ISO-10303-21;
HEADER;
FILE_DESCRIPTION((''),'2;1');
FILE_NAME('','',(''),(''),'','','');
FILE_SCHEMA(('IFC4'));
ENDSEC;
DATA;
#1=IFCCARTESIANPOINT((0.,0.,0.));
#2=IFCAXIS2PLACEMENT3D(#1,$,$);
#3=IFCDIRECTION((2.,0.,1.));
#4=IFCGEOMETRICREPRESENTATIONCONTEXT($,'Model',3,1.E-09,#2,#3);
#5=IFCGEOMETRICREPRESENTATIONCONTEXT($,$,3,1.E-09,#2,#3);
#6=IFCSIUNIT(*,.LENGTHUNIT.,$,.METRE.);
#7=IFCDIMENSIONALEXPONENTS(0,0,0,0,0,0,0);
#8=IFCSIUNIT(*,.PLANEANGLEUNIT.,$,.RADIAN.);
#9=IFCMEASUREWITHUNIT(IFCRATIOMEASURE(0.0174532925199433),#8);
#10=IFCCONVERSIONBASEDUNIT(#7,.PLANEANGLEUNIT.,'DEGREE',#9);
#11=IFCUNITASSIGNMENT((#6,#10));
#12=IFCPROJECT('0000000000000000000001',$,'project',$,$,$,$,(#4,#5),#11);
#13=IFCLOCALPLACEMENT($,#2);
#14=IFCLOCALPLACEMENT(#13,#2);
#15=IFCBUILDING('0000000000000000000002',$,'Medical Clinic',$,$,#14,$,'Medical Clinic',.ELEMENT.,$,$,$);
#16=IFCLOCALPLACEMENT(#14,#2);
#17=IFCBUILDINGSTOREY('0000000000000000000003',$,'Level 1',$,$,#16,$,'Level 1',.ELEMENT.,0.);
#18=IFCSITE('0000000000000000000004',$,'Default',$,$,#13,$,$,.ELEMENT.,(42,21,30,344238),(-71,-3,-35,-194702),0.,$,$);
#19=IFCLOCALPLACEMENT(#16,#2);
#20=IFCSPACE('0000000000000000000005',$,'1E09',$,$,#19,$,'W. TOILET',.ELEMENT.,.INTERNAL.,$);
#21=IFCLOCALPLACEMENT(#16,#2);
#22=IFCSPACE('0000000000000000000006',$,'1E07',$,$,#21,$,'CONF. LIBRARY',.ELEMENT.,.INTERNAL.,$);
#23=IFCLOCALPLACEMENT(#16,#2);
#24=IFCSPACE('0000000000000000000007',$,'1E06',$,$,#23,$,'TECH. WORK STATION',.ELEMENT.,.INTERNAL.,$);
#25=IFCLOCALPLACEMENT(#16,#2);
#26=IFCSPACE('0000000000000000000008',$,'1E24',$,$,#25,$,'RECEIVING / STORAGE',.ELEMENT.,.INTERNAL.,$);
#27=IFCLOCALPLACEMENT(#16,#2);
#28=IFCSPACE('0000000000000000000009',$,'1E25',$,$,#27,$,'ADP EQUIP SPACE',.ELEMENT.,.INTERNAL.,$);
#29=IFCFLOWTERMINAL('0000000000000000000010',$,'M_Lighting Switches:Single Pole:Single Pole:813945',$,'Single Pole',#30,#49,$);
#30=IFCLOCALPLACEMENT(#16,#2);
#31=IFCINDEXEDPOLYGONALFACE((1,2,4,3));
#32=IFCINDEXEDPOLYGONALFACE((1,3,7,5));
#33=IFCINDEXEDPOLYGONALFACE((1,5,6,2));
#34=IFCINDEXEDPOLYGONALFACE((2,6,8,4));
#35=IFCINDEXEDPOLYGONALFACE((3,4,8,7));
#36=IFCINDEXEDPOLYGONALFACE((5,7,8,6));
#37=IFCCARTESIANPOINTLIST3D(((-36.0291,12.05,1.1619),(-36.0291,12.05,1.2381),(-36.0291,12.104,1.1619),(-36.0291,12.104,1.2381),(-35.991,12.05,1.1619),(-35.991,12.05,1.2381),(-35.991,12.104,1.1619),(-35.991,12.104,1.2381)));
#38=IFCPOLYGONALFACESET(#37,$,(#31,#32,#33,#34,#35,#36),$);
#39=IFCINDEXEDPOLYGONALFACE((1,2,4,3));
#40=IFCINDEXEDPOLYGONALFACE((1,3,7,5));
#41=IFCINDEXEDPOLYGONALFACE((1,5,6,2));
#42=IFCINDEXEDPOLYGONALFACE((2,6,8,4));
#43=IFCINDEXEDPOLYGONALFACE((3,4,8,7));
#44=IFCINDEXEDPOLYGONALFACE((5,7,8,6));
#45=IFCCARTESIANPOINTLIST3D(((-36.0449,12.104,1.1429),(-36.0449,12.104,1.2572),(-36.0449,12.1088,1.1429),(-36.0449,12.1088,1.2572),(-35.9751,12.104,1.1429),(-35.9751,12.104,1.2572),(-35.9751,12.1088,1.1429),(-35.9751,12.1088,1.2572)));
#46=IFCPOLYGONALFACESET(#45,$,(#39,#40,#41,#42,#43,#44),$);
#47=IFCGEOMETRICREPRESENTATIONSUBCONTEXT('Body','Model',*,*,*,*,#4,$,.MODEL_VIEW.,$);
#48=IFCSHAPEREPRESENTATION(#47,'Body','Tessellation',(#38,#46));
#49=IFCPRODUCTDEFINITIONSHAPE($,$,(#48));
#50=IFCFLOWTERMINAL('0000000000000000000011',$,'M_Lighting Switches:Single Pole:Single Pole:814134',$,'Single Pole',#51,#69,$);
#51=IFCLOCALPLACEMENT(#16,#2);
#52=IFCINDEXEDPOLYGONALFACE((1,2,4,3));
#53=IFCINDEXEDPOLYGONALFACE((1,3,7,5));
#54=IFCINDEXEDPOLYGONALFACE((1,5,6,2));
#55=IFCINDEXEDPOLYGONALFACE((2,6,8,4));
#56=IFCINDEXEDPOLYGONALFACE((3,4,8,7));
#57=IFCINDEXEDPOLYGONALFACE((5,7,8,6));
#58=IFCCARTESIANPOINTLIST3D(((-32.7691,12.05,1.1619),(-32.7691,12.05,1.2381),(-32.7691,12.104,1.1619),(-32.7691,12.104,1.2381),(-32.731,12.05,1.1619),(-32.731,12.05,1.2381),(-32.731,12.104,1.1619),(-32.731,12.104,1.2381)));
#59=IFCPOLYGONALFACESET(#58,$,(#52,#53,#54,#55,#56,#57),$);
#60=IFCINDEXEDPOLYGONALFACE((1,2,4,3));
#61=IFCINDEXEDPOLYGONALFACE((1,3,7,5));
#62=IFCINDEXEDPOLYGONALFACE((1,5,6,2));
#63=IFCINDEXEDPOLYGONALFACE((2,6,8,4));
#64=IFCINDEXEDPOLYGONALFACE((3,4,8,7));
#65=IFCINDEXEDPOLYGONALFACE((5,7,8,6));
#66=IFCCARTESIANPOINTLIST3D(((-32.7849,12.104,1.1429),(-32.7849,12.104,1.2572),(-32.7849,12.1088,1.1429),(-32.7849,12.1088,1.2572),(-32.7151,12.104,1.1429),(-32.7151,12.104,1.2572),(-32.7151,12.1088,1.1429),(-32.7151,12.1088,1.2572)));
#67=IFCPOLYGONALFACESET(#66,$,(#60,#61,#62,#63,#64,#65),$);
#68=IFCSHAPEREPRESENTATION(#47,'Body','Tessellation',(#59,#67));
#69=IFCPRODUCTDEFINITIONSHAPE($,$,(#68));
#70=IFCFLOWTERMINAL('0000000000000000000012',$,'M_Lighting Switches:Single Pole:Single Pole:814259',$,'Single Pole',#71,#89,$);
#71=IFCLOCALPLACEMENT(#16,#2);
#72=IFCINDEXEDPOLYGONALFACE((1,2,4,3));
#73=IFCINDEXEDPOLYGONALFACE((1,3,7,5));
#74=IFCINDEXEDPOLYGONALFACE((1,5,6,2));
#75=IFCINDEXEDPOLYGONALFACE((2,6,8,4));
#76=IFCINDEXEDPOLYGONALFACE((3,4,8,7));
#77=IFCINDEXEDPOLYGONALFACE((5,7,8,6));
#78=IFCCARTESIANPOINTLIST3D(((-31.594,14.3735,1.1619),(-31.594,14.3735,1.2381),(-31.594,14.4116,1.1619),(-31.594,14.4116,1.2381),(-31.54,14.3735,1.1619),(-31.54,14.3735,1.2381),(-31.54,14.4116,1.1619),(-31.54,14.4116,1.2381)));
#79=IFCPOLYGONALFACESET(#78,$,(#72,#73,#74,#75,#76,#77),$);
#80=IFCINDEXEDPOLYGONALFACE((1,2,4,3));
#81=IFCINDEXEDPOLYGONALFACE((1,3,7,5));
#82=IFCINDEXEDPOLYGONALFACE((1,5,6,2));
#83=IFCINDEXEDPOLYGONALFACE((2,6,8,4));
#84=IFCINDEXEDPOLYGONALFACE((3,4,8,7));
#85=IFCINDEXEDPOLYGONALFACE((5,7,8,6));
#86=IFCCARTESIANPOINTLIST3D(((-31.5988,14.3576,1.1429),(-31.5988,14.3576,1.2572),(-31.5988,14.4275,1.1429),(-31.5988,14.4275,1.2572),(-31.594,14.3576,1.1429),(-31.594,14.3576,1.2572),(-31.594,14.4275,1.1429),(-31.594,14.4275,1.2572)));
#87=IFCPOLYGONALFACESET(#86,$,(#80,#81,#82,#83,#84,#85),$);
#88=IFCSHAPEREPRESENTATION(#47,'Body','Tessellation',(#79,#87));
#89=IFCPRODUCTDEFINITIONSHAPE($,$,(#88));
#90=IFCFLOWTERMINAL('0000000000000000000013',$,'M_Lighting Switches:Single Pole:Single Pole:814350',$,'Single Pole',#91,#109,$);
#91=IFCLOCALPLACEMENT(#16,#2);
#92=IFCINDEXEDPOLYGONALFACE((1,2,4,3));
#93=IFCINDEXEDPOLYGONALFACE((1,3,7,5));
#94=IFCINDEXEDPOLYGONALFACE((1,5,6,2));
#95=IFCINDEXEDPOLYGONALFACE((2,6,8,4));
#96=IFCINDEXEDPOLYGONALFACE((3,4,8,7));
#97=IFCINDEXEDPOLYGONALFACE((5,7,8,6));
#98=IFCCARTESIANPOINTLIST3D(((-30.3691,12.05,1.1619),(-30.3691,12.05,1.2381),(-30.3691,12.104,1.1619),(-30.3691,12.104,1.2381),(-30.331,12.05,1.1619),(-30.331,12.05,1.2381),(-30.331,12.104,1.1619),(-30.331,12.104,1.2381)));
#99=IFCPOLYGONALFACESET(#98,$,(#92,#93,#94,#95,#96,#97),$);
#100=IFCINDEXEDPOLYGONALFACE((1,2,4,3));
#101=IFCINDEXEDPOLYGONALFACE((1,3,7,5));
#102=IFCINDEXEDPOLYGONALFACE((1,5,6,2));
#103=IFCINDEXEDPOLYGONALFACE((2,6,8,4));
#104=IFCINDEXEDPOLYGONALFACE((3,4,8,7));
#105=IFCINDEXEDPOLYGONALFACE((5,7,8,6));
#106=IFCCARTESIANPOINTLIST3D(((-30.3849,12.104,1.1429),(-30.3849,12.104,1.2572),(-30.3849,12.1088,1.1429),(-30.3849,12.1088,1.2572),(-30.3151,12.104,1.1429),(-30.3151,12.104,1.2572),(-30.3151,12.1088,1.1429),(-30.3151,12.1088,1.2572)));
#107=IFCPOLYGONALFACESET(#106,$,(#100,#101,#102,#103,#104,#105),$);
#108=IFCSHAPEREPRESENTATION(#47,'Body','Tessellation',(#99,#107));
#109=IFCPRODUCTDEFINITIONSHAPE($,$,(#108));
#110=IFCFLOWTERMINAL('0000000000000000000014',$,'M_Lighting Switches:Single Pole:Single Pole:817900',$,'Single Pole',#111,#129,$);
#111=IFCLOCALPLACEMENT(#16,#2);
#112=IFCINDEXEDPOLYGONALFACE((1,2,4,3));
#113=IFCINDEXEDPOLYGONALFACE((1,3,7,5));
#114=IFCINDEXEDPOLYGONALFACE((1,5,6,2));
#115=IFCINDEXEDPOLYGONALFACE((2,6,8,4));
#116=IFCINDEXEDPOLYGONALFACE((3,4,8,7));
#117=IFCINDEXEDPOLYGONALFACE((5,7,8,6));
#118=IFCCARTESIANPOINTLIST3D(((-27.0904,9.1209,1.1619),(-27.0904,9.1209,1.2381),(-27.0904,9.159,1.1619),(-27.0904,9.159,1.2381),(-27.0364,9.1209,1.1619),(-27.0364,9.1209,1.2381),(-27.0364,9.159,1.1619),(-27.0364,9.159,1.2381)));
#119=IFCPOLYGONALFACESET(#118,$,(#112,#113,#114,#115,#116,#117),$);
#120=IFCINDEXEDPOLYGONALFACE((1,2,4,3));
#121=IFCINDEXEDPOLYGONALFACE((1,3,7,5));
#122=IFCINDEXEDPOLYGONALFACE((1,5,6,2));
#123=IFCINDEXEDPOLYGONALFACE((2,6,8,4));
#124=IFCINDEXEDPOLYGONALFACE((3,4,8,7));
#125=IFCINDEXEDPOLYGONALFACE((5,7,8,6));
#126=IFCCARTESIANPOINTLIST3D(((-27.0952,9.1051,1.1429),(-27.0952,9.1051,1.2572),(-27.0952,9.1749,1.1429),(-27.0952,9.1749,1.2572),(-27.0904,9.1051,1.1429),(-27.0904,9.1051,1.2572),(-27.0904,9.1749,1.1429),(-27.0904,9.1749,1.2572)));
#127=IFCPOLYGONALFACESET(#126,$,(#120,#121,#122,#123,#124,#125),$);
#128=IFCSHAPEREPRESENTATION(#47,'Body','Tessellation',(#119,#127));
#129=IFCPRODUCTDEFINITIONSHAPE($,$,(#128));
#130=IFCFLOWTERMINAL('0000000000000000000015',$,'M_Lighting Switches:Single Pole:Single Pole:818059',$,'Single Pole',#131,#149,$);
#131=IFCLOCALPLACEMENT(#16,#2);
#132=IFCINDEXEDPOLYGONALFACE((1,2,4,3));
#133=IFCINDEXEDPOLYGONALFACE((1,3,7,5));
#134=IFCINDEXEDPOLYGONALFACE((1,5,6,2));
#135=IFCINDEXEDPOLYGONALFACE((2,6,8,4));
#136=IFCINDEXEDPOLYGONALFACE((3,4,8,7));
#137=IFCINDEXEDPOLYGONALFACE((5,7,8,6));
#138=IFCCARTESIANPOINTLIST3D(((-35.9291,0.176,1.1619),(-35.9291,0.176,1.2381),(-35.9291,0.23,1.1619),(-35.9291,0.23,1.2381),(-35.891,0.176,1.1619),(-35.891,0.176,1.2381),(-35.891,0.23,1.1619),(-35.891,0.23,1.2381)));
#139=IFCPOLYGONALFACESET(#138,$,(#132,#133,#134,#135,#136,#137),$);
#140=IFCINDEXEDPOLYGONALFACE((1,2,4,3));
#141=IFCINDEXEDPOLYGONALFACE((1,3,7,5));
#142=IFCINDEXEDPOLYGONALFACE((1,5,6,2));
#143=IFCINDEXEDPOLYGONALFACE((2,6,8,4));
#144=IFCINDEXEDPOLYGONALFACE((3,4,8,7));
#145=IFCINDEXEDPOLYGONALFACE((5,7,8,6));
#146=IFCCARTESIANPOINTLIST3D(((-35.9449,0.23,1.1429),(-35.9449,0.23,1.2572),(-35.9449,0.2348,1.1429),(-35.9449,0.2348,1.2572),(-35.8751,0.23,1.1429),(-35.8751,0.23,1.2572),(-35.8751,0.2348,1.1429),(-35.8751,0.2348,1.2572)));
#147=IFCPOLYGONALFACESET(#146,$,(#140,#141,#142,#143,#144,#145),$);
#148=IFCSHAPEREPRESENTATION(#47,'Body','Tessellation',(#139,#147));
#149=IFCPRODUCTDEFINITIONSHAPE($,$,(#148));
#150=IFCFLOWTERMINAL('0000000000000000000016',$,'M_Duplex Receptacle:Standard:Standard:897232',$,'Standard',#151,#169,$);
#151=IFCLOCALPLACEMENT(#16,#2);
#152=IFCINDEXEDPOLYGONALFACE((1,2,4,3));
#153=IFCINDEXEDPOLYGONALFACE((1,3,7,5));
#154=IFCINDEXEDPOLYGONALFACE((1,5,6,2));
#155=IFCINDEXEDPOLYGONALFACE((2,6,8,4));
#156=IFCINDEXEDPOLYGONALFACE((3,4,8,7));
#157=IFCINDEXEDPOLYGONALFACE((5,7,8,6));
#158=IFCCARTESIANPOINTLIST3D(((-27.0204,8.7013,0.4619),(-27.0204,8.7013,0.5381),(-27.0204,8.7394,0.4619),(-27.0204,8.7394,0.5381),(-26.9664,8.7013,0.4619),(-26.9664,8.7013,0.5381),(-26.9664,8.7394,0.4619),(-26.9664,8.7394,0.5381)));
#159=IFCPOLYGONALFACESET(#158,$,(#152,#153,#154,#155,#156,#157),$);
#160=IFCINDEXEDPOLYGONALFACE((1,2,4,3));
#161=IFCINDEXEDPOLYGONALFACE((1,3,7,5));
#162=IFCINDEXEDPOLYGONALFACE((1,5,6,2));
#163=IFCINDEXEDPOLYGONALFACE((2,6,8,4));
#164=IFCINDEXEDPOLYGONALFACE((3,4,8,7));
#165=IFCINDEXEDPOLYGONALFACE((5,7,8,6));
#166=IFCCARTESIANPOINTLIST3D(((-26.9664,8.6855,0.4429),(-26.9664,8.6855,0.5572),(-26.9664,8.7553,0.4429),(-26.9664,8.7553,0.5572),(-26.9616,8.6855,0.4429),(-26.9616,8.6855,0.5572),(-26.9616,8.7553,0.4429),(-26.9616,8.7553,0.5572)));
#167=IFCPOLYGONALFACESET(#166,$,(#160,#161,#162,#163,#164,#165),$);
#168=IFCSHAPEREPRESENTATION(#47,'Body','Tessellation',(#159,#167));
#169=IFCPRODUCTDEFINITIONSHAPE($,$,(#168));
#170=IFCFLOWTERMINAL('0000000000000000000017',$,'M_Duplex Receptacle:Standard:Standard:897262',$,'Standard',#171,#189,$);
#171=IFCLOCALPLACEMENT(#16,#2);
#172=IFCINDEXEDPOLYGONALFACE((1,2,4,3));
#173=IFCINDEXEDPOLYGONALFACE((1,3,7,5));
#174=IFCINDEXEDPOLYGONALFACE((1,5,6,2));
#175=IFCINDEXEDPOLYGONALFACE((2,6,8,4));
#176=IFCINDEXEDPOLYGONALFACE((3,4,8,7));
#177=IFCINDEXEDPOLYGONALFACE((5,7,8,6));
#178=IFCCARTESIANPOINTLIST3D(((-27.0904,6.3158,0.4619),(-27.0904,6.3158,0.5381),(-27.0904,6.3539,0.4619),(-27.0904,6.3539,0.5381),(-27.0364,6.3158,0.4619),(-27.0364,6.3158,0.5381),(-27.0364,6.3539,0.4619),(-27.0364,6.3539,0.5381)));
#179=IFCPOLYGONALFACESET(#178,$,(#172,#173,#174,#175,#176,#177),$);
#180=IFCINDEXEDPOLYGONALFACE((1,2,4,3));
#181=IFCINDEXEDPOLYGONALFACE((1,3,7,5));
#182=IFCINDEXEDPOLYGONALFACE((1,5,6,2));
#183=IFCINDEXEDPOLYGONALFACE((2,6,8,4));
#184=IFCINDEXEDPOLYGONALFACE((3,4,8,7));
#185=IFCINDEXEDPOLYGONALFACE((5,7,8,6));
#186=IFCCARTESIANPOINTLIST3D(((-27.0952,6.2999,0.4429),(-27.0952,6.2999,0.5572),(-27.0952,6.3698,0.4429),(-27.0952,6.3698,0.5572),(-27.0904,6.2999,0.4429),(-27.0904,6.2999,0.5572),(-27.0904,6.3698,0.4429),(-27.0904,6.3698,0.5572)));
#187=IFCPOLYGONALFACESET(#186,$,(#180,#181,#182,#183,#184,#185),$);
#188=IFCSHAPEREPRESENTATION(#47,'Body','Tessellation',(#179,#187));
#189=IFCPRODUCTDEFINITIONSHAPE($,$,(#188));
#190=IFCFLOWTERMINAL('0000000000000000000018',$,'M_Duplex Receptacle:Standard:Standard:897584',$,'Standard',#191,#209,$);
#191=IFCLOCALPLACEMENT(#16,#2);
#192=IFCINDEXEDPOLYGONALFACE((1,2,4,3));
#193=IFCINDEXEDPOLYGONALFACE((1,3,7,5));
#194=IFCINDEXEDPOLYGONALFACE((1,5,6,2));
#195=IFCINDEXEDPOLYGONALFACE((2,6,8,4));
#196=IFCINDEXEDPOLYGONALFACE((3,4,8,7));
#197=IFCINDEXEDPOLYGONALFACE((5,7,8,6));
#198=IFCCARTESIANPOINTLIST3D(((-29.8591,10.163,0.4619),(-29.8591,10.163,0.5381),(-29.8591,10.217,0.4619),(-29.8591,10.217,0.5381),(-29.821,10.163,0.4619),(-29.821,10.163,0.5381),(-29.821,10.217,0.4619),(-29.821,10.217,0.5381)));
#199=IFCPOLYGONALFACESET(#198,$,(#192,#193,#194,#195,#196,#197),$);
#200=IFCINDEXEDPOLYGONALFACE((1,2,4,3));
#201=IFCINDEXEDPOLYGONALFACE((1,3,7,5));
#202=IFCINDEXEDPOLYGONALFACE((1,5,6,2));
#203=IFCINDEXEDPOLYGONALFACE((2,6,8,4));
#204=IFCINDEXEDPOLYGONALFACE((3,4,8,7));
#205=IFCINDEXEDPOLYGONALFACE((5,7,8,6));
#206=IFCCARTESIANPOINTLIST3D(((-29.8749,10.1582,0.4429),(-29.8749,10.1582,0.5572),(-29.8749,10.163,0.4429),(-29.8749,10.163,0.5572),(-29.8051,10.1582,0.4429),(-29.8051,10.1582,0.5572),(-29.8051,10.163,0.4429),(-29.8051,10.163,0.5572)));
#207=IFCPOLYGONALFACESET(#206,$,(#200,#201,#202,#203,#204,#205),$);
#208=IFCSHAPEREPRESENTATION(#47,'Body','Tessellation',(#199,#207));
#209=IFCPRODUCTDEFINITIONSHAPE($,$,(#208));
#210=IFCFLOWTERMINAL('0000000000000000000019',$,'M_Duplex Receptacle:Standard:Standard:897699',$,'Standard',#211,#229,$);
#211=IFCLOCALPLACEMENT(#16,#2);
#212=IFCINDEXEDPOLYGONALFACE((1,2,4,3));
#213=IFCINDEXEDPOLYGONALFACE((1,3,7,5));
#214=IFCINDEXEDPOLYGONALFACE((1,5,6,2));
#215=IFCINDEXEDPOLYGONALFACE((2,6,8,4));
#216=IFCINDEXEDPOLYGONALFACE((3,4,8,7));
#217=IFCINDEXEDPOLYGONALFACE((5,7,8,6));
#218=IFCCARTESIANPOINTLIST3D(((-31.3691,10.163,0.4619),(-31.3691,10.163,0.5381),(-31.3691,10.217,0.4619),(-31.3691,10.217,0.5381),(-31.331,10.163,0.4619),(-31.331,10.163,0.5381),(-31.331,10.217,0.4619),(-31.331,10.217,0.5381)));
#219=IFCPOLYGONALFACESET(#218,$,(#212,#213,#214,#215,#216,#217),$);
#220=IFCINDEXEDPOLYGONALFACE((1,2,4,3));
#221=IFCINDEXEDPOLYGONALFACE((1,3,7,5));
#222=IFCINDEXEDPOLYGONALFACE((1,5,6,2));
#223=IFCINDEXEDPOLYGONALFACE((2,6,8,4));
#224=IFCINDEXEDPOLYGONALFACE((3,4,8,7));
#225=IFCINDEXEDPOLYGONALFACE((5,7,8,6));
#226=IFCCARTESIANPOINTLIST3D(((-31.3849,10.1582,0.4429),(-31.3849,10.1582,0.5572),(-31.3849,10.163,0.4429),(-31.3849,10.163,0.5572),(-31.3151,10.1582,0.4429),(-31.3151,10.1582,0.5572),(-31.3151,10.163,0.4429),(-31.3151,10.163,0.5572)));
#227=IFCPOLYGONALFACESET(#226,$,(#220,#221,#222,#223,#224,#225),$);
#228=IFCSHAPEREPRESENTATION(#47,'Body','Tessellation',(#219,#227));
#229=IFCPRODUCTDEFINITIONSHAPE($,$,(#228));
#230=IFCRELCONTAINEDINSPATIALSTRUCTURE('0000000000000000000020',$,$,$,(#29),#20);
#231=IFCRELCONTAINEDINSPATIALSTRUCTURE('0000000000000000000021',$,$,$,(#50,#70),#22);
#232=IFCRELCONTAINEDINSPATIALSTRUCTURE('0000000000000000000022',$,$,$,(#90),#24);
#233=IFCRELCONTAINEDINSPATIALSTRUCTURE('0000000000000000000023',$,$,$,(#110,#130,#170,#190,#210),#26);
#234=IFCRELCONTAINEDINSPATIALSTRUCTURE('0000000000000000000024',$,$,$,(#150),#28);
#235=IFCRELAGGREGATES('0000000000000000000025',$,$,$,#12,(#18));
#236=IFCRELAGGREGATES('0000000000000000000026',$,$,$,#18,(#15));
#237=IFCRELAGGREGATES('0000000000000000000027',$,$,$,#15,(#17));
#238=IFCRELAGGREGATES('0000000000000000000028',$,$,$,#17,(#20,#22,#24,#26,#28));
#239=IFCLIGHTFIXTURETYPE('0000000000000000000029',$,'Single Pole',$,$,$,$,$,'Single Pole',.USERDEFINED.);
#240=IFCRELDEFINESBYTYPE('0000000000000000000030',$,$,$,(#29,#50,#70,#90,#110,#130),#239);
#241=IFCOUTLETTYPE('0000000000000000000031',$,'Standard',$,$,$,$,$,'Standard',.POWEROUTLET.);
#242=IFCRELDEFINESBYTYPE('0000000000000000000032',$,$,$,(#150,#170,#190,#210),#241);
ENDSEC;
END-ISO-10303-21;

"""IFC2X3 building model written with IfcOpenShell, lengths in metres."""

from ifc_helpers import new_model, entity, si_unit, converted_unit, direction, frame, frame_2d, origin, origin_2d_with_axis, place, context, subcontext, project, spatial, rectangle, extrude, source, transform, mapped, type_object, type_shapes, element, save


model = new_model("IFC2X3")

# Units and contexts
model_context = context("Model", 3, precision=1e-09, world=origin(), true_north=direction((2.0, 0.0, 1.0)))
context_of_model = context(None, 3, precision=1e-09, world=origin(), true_north=direction((2.0, 0.0, 1.0)))
body_context = subcontext(model_context, "Body", "Model", "MODEL_VIEW")
ifc_project = project(units=[si_unit("LENGTHUNIT", "METRE"), converted_unit("PLANEANGLEUNIT", "DEGREE", entity("IfcRatioMeasure", 0.0174532925199433), si_unit("PLANEANGLEUNIT", "RADIAN"), dimensions=[0, 0, 0, 0, 0, 0, 0])], contexts=[model_context, context_of_model])

# Site, building, storey, space
site_placement = place(None, origin())
site = spatial("IfcSite", under=ifc_project, at=site_placement, Name="Default", CompositionType="ELEMENT", RefLatitude=(42, 21, 30, 344238), RefLongitude=(-71, -3, -35, -194702), RefElevation=0.0)
building_placement = place(site_placement, origin())
building = spatial("IfcBuilding", under=site, at=building_placement, Name="Medical Clinic", LongName="Medical Clinic", CompositionType="ELEMENT")
storey_placement = place(building_placement, origin())
storey = spatial("IfcBuildingStorey", under=building, at=storey_placement, Name="Level 1", LongName="Level 1", CompositionType="ELEMENT", Elevation=0.0)
space_1_placement = place(storey_placement, origin())
space_1 = spatial("IfcSpace", under=storey, at=space_1_placement, Name="1E09", LongName="W. TOILET", CompositionType="ELEMENT", InteriorOrExteriorSpace="INTERNAL")

# Flow terminal
light_fixture_type_1 = type_object("IfcLightFixtureType", Name="Single Pole", ElementType="Single Pole", PredefinedType="USERDEFINED")
shared_shape_1 = source(origin(), body_context, "Body", "SweptSolid", [
    extrude(rectangle(XDim=0.0381, YDim=0.0762, at=origin_2d_with_axis()), frame((0.0, 0.0, -0.054), z_axis=(0.0, 0.0, 1.0), x_axis=(-1.0, 0.0, 0.0)), (0.0, 0.0, 1.0), 0.054),
    extrude(rectangle(XDim=0.0698, YDim=0.1143, at=frame_2d((0.0, 0.0), x_axis=(1.0, 0.0))), frame((0.0, 0.0, 0.0), z_axis=(0.0, 0.0, 1.0), x_axis=(-1.0, 0.0, 0.0)), (0.0, 0.0, 1.0), 0.0048),
])
type_shapes(light_fixture_type_1, [shared_shape_1])
flow_terminal_1_placement = place(space_1_placement, frame((-36.01, 12.104, 1.2), z_axis=(0.0, 1.0, 0.0), x_axis=(-1.0, 0.0, 0.0)))
element("IfcFlowTerminal", 1, at=flow_terminal_1_placement, inside=space_1, type_object=light_fixture_type_1, Name="M_Lighting Switches:Single Pole:Single Pole:813945", ObjectType="Single Pole", context=body_context, shape_type="MappedRepresentation", body=[
    mapped(shared_shape_1, transform((0.0, 0.0, 0.0), scale=1.0)),
])

# Shared definitions
space_2_placement = place(storey_placement, origin())
space_2 = spatial("IfcSpace", under=storey, at=space_2_placement, Name="1E07", LongName="CONF. LIBRARY", CompositionType="ELEMENT", InteriorOrExteriorSpace="INTERNAL")

# Flow terminals
for number, where, z_axis, x_axis, name in (
    (2, (-32.75, 12.104, 1.2), (0.0, 1.0, 0.0), (-1.0, 0.0, 0.0), "M_Lighting Switches:Single Pole:Single Pole:814134"),
    (3, (-31.594, 14.3925, 1.2), (-1.0, 0.0, 0.0), (0.0, -1.0, 0.0), "M_Lighting Switches:Single Pole:Single Pole:814259"),
):
    element("IfcFlowTerminal", number, at=place(space_2_placement, frame(where, z_axis=z_axis, x_axis=x_axis)), inside=space_2, type_object=light_fixture_type_1, Name=name, ObjectType="Single Pole", context=body_context, shape_type="MappedRepresentation", body=[
        mapped(shared_shape_1, transform((0.0, 0.0, 0.0), scale=1.0)),
    ])

# Shared definitions
space_3_placement = place(storey_placement, origin())
space_3 = spatial("IfcSpace", under=storey, at=space_3_placement, Name="1E06", LongName="TECH. WORK STATION", CompositionType="ELEMENT", InteriorOrExteriorSpace="INTERNAL")

# Flow terminal
flow_terminal_2_placement = place(space_3_placement, frame((-30.35, 12.104, 1.2), z_axis=(0.0, 1.0, 0.0), x_axis=(-1.0, 0.0, 0.0)))
element("IfcFlowTerminal", 4, at=flow_terminal_2_placement, inside=space_3, type_object=light_fixture_type_1, Name="M_Lighting Switches:Single Pole:Single Pole:814350", ObjectType="Single Pole", context=body_context, shape_type="MappedRepresentation", body=[
    mapped(shared_shape_1, transform((0.0, 0.0, 0.0), scale=1.0)),
])

# Shared definitions
space_4_placement = place(storey_placement, origin())
space_4 = spatial("IfcSpace", under=storey, at=space_4_placement, Name="1E24", LongName="RECEIVING / STORAGE", CompositionType="ELEMENT", InteriorOrExteriorSpace="INTERNAL")

# Flow terminals
for number, where, z_axis, x_axis, name in (
    (5, (-27.0904, 9.14, 1.2), (-1.0, 0.0, 0.0), (0.0, -1.0, 0.0), "M_Lighting Switches:Single Pole:Single Pole:817900"),
    (6, (-35.91, 0.23, 1.2), (0.0, 1.0, 0.0), (-1.0, 0.0, 0.0), "M_Lighting Switches:Single Pole:Single Pole:818059"),
):
    element("IfcFlowTerminal", number, at=place(space_4_placement, frame(where, z_axis=z_axis, x_axis=x_axis)), inside=space_4, type_object=light_fixture_type_1, Name=name, ObjectType="Single Pole", context=body_context, shape_type="MappedRepresentation", body=[
        mapped(shared_shape_1, transform((0.0, 0.0, 0.0), scale=1.0)),
    ])

# Shared definitions
space_5_placement = place(storey_placement, origin())
space_5 = spatial("IfcSpace", under=storey, at=space_5_placement, Name="1E25", LongName="ADP EQUIP SPACE", CompositionType="ELEMENT", InteriorOrExteriorSpace="INTERNAL")

# Flow terminals
outlet_type = type_object("IfcOutletType", Name="Standard", ElementType="Standard", PredefinedType="POWEROUTLET")
shared_shape_2 = source(origin(), body_context, "Body", "SweptSolid", [
    extrude(rectangle(XDim=0.0381, YDim=0.0762, at=origin_2d_with_axis()), frame((0.0, 0.0, -0.054), z_axis=(0.0, 0.0, 1.0), x_axis=(-1.0, 0.0, 0.0)), (0.0, 0.0, 1.0), 0.054),
    extrude(rectangle(XDim=0.0698, YDim=0.1143, at=frame_2d((0.0, 0.0), x_axis=(1.0, 0.0))), frame((0.0, 0.0, 0.0), z_axis=(0.0, 0.0, 1.0), x_axis=(-1.0, 0.0, 0.0)), (0.0, 0.0, 1.0), 0.0048),
])
type_shapes(outlet_type, [shared_shape_2])
flow_terminal_3_placement = place(space_5_placement, frame((-26.9664, 8.7204, 0.5), z_axis=(1.0, 0.0, 0.0), x_axis=(0.0, 1.0, 0.0)))
element("IfcFlowTerminal", 7, at=flow_terminal_3_placement, inside=space_5, type_object=outlet_type, Name="M_Duplex Receptacle:Standard:Standard:897232", ObjectType="Standard", context=body_context, shape_type="MappedRepresentation", body=[
    mapped(shared_shape_2, transform((0.0, 0.0, 0.0), scale=1.0)),
])
for number, where, z_axis, x_axis, name in (
    (8, (-27.0904, 6.3349, 0.5), (-1.0, 0.0, 0.0), (0.0, -1.0, 0.0), "M_Duplex Receptacle:Standard:Standard:897262"),
    (9, (-29.84, 10.163, 0.5), (0.0, -1.0, 0.0), (1.0, 0.0, 0.0), "M_Duplex Receptacle:Standard:Standard:897584"),
    (10, (-31.35, 10.163, 0.5), (0.0, -1.0, 0.0), (1.0, 0.0, 0.0), "M_Duplex Receptacle:Standard:Standard:897699"),
):
    element("IfcFlowTerminal", number, at=place(space_4_placement, frame(where, z_axis=z_axis, x_axis=x_axis)), inside=space_4, type_object=outlet_type, Name=name, ObjectType="Standard", context=body_context, shape_type="MappedRepresentation", body=[
        mapped(shared_shape_2, transform((0.0, 0.0, 0.0), scale=1.0)),
    ])

save(model, "model.ifc")
